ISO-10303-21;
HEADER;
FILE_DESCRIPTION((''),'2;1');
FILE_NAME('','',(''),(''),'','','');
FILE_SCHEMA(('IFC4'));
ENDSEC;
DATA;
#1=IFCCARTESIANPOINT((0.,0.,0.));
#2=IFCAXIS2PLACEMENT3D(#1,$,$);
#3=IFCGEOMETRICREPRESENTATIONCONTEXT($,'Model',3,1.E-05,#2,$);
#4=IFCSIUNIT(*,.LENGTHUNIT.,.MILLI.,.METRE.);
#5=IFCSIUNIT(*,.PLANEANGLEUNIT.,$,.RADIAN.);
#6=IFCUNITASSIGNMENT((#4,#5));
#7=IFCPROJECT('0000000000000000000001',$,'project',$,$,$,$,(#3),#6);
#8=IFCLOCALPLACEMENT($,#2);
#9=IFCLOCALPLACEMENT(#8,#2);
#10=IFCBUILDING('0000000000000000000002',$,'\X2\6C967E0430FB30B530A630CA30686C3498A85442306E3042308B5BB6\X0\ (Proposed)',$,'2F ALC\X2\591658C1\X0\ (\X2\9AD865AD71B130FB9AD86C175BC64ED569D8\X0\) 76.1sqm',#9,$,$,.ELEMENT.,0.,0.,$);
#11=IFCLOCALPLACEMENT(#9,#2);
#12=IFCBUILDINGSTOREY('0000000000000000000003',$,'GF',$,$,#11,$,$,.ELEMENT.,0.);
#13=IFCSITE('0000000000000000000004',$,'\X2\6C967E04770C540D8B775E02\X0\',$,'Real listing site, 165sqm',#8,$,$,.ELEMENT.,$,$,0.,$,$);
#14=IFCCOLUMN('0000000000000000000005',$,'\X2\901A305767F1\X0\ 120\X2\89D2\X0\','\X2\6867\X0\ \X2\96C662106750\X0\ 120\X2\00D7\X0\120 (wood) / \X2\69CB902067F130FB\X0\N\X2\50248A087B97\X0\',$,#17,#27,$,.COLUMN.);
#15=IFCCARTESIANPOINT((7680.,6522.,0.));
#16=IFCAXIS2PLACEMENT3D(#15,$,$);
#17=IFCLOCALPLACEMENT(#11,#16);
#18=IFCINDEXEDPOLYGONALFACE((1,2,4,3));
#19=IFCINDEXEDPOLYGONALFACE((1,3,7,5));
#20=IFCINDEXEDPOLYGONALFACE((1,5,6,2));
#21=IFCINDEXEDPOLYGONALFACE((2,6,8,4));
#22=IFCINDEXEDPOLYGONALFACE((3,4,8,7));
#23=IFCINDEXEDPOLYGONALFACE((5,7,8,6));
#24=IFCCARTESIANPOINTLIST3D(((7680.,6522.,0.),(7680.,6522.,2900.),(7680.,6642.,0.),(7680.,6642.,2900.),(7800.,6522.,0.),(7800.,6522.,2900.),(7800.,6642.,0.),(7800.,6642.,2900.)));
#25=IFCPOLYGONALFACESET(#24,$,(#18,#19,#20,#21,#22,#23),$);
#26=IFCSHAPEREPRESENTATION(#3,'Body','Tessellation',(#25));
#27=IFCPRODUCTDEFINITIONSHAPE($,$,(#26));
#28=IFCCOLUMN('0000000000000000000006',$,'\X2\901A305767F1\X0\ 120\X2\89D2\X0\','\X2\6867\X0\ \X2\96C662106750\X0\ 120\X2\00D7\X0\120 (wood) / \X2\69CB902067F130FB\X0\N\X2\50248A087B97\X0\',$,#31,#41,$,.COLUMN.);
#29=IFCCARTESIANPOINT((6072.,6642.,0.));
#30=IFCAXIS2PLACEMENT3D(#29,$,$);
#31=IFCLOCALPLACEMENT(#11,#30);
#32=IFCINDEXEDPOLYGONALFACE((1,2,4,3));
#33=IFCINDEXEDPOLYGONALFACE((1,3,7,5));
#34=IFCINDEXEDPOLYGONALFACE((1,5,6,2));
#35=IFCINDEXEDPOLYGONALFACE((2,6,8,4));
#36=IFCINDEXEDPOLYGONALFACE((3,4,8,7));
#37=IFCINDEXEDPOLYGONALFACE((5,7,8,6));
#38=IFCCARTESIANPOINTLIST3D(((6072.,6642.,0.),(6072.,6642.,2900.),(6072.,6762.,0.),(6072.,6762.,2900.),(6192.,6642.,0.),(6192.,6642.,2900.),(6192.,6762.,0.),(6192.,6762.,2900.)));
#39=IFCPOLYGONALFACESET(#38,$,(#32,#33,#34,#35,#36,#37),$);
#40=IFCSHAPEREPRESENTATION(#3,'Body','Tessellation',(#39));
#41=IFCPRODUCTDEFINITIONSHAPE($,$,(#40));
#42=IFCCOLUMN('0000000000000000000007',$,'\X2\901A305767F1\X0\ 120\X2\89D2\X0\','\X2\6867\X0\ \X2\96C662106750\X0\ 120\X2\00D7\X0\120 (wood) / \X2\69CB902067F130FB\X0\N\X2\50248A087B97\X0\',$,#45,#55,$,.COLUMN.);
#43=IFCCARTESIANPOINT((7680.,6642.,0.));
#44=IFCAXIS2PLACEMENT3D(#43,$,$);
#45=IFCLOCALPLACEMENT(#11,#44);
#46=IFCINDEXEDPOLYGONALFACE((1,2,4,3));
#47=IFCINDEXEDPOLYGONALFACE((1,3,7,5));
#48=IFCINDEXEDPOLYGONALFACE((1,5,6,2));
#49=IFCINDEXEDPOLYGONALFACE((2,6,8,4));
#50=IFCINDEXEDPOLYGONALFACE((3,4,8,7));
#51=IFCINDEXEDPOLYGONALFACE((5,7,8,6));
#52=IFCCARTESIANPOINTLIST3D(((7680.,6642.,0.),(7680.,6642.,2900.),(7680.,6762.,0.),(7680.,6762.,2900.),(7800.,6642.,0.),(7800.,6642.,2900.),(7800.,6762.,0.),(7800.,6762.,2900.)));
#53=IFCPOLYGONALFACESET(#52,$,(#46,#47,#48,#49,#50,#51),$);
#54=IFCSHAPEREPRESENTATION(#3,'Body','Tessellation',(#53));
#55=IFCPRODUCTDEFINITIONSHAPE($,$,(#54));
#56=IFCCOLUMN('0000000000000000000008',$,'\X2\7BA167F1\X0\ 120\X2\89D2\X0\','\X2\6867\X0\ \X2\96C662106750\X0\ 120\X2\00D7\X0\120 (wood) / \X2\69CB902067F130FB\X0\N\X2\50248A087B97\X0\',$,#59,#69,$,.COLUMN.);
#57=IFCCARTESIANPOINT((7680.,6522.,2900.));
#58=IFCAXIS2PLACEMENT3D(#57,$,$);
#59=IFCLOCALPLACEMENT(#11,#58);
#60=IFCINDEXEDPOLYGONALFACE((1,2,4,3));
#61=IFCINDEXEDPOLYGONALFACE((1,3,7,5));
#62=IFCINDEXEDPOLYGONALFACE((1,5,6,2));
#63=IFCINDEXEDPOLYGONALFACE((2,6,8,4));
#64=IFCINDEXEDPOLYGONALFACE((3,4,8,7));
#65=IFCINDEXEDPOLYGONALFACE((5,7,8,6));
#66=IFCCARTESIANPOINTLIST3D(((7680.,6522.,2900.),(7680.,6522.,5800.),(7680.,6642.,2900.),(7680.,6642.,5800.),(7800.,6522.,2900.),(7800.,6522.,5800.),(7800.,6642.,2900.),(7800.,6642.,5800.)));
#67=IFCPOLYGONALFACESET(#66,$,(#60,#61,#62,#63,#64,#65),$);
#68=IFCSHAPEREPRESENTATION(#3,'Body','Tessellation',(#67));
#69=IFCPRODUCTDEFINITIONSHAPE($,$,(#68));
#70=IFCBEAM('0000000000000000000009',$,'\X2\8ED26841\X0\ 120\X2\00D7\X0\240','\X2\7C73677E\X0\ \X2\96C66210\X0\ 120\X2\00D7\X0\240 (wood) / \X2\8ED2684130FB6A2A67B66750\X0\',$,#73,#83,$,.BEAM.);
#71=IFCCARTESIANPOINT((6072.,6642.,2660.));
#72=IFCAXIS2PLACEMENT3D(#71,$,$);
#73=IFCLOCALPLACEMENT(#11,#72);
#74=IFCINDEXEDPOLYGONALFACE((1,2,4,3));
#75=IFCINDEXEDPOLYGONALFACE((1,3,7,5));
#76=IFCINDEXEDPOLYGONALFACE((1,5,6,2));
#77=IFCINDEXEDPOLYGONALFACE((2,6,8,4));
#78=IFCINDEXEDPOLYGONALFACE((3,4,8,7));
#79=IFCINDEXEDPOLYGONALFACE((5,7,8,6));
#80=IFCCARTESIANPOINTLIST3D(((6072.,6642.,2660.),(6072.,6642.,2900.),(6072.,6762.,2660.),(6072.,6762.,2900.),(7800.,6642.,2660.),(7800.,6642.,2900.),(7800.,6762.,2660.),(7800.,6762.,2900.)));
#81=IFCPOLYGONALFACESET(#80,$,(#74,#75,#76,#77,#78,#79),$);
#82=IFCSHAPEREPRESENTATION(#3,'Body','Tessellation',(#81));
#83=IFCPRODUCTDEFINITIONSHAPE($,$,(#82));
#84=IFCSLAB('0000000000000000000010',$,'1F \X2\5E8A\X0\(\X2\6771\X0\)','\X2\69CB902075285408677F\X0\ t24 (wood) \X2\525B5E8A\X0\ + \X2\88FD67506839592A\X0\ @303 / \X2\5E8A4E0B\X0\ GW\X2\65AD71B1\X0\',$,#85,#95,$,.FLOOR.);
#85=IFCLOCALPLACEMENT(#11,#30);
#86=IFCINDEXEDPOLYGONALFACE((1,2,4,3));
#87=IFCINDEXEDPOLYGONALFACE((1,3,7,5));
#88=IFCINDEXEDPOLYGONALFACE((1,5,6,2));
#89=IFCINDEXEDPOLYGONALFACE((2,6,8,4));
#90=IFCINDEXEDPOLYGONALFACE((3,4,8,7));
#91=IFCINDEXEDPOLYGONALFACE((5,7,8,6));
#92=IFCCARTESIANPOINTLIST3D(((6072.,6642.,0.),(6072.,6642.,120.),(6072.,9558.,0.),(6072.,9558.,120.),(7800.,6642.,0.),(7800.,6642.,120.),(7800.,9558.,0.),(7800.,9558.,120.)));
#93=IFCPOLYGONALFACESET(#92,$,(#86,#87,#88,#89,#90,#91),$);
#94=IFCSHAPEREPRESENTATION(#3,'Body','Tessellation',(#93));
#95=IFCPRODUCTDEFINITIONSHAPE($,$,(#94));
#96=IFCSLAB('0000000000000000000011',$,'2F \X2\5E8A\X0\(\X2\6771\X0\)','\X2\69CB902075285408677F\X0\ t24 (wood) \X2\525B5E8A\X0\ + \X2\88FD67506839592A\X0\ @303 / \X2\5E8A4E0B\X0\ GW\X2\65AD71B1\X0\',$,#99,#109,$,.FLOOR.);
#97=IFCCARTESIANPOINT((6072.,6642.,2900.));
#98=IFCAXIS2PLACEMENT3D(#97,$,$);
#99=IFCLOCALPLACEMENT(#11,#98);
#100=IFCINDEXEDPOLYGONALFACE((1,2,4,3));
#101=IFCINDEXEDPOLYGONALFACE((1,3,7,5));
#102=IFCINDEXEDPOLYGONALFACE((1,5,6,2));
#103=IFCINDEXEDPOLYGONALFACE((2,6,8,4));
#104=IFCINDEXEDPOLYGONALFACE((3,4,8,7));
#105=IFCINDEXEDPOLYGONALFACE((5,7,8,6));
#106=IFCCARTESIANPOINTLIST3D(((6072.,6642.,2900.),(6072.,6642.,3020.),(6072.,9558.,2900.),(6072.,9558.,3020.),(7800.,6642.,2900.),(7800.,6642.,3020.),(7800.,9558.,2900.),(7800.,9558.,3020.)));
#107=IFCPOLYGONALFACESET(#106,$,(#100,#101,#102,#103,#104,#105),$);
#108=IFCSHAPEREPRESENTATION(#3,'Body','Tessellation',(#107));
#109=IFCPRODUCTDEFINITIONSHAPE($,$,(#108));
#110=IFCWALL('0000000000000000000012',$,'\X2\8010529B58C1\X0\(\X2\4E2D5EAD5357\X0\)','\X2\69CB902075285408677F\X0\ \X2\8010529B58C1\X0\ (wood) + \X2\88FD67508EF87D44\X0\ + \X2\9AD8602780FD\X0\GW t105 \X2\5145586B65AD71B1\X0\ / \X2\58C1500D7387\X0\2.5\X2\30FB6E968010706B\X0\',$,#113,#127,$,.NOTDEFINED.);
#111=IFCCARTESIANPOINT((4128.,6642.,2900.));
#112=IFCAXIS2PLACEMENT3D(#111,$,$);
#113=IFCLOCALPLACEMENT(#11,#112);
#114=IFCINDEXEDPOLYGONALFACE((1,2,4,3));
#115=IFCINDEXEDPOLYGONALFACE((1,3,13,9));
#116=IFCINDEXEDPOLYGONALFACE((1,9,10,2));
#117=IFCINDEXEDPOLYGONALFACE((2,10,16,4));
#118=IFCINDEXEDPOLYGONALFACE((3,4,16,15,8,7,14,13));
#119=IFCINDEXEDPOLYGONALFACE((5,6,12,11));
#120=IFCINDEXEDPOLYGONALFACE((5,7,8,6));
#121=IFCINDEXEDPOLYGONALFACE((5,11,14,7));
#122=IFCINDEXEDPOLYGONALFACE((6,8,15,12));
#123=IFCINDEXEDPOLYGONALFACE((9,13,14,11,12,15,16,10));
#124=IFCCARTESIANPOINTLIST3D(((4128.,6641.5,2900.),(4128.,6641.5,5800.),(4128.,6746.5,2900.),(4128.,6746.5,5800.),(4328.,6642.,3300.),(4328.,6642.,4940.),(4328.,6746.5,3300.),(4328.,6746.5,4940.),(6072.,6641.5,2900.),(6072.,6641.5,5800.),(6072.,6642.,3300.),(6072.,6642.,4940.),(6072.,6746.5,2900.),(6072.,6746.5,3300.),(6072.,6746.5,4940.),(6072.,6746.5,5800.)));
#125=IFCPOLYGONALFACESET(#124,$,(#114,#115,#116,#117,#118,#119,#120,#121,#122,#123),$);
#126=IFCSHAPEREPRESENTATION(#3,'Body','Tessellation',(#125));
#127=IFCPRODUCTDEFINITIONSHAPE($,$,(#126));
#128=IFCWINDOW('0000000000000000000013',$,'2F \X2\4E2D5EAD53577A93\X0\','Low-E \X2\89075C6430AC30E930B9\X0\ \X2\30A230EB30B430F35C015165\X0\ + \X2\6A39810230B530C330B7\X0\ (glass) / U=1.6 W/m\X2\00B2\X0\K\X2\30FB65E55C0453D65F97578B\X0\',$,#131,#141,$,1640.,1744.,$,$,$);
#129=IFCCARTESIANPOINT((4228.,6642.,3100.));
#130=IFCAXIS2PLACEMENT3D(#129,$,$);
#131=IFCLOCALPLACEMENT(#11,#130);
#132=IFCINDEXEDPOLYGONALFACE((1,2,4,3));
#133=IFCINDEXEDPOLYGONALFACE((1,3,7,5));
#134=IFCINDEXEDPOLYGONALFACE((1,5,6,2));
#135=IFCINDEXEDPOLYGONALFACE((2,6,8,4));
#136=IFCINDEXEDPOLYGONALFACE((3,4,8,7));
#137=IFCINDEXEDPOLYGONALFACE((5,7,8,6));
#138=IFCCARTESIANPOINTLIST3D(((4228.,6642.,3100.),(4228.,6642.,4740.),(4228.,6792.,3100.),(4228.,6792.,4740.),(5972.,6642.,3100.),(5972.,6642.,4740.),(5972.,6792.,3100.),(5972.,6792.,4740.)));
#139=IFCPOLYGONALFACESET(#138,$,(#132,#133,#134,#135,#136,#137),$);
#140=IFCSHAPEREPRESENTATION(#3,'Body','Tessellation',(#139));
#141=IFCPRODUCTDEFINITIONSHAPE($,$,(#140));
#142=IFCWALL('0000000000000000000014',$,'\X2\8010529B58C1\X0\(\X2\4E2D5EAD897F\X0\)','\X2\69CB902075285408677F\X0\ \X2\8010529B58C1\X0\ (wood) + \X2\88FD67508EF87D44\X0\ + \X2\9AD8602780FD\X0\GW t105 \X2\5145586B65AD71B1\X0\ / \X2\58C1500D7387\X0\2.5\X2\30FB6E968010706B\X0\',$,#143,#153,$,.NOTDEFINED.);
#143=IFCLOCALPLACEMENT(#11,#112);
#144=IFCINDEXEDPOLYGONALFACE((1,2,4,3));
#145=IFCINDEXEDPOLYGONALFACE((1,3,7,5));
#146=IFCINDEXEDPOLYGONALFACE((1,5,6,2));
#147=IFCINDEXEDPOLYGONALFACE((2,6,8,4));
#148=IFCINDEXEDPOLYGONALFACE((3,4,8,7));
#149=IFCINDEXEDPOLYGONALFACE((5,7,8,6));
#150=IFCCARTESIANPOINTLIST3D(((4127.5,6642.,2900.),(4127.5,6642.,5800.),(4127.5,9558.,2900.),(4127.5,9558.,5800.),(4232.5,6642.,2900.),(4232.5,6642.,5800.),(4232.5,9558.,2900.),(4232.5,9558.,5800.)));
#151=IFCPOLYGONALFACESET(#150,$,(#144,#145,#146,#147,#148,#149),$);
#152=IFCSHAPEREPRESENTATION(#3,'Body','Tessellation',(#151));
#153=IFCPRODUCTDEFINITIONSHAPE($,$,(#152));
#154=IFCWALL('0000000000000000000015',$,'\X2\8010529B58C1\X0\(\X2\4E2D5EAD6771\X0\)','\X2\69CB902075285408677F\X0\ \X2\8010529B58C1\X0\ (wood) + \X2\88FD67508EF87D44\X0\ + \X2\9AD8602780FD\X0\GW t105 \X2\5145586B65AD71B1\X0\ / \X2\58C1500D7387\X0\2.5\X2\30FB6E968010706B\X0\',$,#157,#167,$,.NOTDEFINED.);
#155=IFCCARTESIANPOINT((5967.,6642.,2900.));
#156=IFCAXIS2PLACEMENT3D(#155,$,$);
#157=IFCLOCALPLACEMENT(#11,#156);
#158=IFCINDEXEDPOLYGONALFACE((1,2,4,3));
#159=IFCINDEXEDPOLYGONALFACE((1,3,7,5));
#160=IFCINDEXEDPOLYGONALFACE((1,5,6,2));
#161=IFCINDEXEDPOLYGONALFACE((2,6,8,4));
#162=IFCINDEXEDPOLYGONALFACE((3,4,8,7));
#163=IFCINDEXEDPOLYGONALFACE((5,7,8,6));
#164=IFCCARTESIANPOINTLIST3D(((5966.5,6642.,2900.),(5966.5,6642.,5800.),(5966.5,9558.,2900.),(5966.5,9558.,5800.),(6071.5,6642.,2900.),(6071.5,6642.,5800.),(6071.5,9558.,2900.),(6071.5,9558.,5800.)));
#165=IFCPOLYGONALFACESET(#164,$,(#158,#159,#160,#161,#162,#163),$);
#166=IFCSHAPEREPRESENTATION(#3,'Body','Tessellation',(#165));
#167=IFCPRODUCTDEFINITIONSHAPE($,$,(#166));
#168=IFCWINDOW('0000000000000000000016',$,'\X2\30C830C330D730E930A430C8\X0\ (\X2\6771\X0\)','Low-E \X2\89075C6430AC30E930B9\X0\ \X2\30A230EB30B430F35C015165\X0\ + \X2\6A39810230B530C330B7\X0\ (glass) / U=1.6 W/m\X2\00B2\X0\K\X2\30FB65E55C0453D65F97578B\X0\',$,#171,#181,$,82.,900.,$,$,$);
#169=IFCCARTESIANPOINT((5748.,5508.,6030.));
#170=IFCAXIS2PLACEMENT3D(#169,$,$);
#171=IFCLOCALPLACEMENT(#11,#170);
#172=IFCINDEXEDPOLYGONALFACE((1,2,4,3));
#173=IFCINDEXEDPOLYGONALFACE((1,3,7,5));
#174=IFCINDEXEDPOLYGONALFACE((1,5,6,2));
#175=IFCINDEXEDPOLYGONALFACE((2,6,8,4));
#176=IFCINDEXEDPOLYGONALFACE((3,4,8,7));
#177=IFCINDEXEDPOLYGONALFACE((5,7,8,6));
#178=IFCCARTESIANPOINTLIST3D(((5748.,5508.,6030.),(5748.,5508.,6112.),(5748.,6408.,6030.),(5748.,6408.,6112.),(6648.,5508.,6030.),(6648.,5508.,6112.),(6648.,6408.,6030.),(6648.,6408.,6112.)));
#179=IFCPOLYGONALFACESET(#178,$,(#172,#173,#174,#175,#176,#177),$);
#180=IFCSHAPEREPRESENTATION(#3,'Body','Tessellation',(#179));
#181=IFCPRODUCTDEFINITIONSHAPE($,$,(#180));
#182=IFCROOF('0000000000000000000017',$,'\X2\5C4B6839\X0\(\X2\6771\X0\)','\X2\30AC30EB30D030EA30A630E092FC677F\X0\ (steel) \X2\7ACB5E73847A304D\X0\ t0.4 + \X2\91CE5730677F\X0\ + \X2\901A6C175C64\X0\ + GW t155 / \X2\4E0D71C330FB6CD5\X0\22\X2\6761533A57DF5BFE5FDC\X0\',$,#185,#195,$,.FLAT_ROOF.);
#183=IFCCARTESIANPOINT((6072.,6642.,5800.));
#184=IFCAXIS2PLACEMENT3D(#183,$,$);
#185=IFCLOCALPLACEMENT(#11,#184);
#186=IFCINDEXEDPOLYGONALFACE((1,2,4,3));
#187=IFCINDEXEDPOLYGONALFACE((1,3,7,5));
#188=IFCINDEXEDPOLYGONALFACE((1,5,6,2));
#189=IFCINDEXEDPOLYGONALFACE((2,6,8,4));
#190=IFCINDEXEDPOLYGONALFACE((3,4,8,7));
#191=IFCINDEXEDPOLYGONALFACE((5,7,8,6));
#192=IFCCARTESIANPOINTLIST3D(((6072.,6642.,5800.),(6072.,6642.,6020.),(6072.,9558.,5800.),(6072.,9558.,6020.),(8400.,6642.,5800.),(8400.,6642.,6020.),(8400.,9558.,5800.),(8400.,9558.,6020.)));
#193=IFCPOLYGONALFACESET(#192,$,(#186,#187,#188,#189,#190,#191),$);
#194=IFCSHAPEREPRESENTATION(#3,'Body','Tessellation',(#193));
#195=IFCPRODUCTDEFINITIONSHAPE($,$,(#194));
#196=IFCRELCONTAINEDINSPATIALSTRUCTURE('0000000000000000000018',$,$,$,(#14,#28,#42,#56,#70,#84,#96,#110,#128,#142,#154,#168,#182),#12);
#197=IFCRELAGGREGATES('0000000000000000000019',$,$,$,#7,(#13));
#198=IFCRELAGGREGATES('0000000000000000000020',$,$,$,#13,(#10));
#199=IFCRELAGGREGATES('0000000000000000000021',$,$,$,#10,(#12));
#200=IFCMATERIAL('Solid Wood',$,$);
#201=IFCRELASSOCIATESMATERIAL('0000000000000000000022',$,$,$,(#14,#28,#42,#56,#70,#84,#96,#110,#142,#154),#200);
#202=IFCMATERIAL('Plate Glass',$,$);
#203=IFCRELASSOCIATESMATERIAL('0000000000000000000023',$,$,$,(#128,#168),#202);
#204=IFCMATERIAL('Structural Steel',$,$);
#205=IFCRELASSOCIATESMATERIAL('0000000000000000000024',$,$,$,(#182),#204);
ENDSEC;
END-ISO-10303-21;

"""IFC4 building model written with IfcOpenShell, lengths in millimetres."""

from ifc_helpers import new_model, si_unit, frame, frame_2d, origin, place, context, project, spatial, rectangle, extrude, material, element, fill, save


model = new_model("IFC4")

# Units and contexts
model_context = context("Model", 3, precision=1e-05, world=origin())
ifc_project = project(units=[si_unit("LENGTHUNIT", "METRE", prefix="MILLI"), si_unit("PLANEANGLEUNIT", "RADIAN")], contexts=[model_context])

# Site, building, storey
site_placement = place(None, origin())
site = spatial("IfcSite", under=ifc_project, at=site_placement, Name="沖縄県名護市", ObjectType="Real listing site, 165sqm", CompositionType="ELEMENT", RefElevation=0.0)
building_placement = place(site_placement, origin())
building = spatial("IfcBuilding", under=site, at=building_placement, Name="沖縄・サウナと水風呂のある家 (Proposed)", ObjectType="2F ALC外壁 (高断熱・高気密仕様) 76.1sqm", CompositionType="ELEMENT", ElevationOfRefHeight=0.0, ElevationOfTerrain=0.0)
storey_placement = place(building_placement, origin())
storey = spatial("IfcBuildingStorey", under=building, at=storey_placement, Name="GF", CompositionType="ELEMENT", Elevation=0.0)

# Columns
ifc_material_1 = material(Name="Solid Wood")
column_1_placement = place(storey_placement, frame((7680.0, 6522.0, 0.0)))
element("IfcColumn", 1, at=column_1_placement, inside=storey, material=ifc_material_1, Name="通し柱 120角", Description="桧 集成材 120×120 (wood) / 構造柱・N値計算", PredefinedType="COLUMN", context=model_context, shape_type="SweptSolid", body=[
    extrude(rectangle(XDim=120.0, YDim=120.0, at=frame_2d((60.0, 60.0))), frame((7680.0, 6522.0, 0.0)), (0.0, 0.0, 1.0), 2900.0),
])
column_2_placement = place(storey_placement, frame((6072.0, 6642.0, 0.0)))
element("IfcColumn", 2, at=column_2_placement, inside=storey, material=ifc_material_1, Name="通し柱 120角", Description="桧 集成材 120×120 (wood) / 構造柱・N値計算", PredefinedType="COLUMN", context=model_context, shape_type="SweptSolid", body=[
    extrude(rectangle(XDim=120.0, YDim=120.0, at=frame_2d((60.0, 60.0))), frame((6072.0, 6642.0, 0.0)), (0.0, 0.0, 1.0), 2900.0),
])
column_3_placement = place(storey_placement, frame((7680.0, 6642.0, 0.0)))
element("IfcColumn", 3, at=column_3_placement, inside=storey, material=ifc_material_1, Name="通し柱 120角", Description="桧 集成材 120×120 (wood) / 構造柱・N値計算", PredefinedType="COLUMN", context=model_context, shape_type="SweptSolid", body=[
    extrude(rectangle(XDim=120.0, YDim=120.0, at=frame_2d((60.0, 60.0))), frame((7680.0, 6642.0, 0.0)), (0.0, 0.0, 1.0), 2900.0),
])
column_4_placement = place(storey_placement, frame((7680.0, 6522.0, 2900.0)))
element("IfcColumn", 4, at=column_4_placement, inside=storey, material=ifc_material_1, Name="管柱 120角", Description="桧 集成材 120×120 (wood) / 構造柱・N値計算", PredefinedType="COLUMN", context=model_context, shape_type="SweptSolid", body=[
    extrude(rectangle(XDim=120.0, YDim=120.0, at=frame_2d((60.0, 60.0))), frame((7680.0, 6522.0, 2900.0)), (0.0, 0.0, 1.0), 2900.0),
])

# Beam
beam_1_placement = place(storey_placement, frame((6072.0, 6642.0, 2660.0)))
element("IfcBeam", 5, at=beam_1_placement, inside=storey, material=ifc_material_1, Name="軒桁 120×240", Description="米松 集成 120×240 (wood) / 軒桁・横架材", PredefinedType="BEAM", context=model_context, shape_type="SweptSolid", body=[
    extrude(rectangle(XDim=1728.0, YDim=120.0, at=frame_2d((864.0, 60.0))), frame((6072.0, 6642.0, 2660.0)), (0.0, 0.0, 1.0), 240.0),
])

# Slabs
slab_1_placement = place(storey_placement, frame((6072.0, 6642.0, 0.0)))
element("IfcSlab", 6, at=slab_1_placement, inside=storey, material=ifc_material_1, Name="1F 床(東)", Description="構造用合板 t24 (wood) 剛床 + 製材根太 @303 / 床下 GW断熱", PredefinedType="FLOOR", context=model_context, shape_type="SweptSolid", body=[
    extrude(rectangle(XDim=1728.0, YDim=2916.0, at=frame_2d((864.0, 1458.0))), frame((6072.0, 6642.0, 0.0)), (0.0, 0.0, 1.0), 120.0),
])
slab_2_placement = place(storey_placement, frame((6072.0, 6642.0, 2900.0)))
element("IfcSlab", 7, at=slab_2_placement, inside=storey, material=ifc_material_1, Name="2F 床(東)", Description="構造用合板 t24 (wood) 剛床 + 製材根太 @303 / 床下 GW断熱", PredefinedType="FLOOR", context=model_context, shape_type="SweptSolid", body=[
    extrude(rectangle(XDim=1728.0, YDim=2916.0, at=frame_2d((864.0, 1458.0))), frame((6072.0, 6642.0, 2900.0)), (0.0, 0.0, 1.0), 120.0),
])

# Wall, opening, window
wall_1_placement = place(storey_placement, frame((4128.0, 6642.0, 2900.0)))
wall_1 = element("IfcWall", 8, at=wall_1_placement, inside=storey, material=ifc_material_1, Name="耐力壁(中庭南)", Description="構造用合板 耐力壁 (wood) + 製材軸組 + 高性能GW t105 充填断熱 / 壁倍率2.5・準耐火", PredefinedType="NOTDEFINED", context=model_context, shape_type="SweptSolid", body=[
    extrude(rectangle(XDim=1944.0, YDim=105.0, at=frame_2d((972.0, 52.0))), frame((4128.0, 6642.0, 2900.0)), (0.0, 0.0, 1.0), 2900.0),
])
opening_placement = place(storey_placement, frame((4228.0, 6642.0, 3100.0)))
opening = element("IfcOpeningElement", 9, at=opening_placement, cuts=wall_1, PredefinedType="NOTDEFINED", context=model_context, shape_type="SweptSolid", body=[
    extrude(rectangle(XDim=1744.0, YDim=150.0, at=frame_2d((872.0, 75.0))), frame((4228.0, 6642.0, 3100.0)), (0.0, 0.0, 1.0), 1640.0),
])
ifc_material_2 = material(Name="Plate Glass")
window_1_placement = place(storey_placement, frame((4228.0, 6642.0, 3100.0)))
window_1 = element("IfcWindow", 10, at=window_1_placement, inside=storey, material=ifc_material_2, Name="2F 中庭南窓", Description="Low-E 複層ガラス アルゴン封入 + 樹脂サッシ (glass) / U=1.6 W/m²K・日射取得型", OverallHeight=1640.0, OverallWidth=1744.0, context=model_context, shape_type="SweptSolid", body=[
    extrude(rectangle(XDim=1744.0, YDim=150.0, at=frame_2d((872.0, 75.0))), frame((4228.0, 6642.0, 3100.0)), (0.0, 0.0, 1.0), 1640.0),
])
fill(opening, window_1)

# Walls
wall_2_placement = place(storey_placement, frame((4128.0, 6642.0, 2900.0)))
element("IfcWall", 11, at=wall_2_placement, inside=storey, material=ifc_material_1, Name="耐力壁(中庭西)", Description="構造用合板 耐力壁 (wood) + 製材軸組 + 高性能GW t105 充填断熱 / 壁倍率2.5・準耐火", PredefinedType="NOTDEFINED", context=model_context, shape_type="SweptSolid", body=[
    extrude(rectangle(XDim=105.0, YDim=2916.0, at=frame_2d((52.0, 1458.0))), frame((4128.0, 6642.0, 2900.0)), (0.0, 0.0, 1.0), 2900.0),
])
wall_3_placement = place(storey_placement, frame((5967.0, 6642.0, 2900.0)))
element("IfcWall", 12, at=wall_3_placement, inside=storey, material=ifc_material_1, Name="耐力壁(中庭東)", Description="構造用合板 耐力壁 (wood) + 製材軸組 + 高性能GW t105 充填断熱 / 壁倍率2.5・準耐火", PredefinedType="NOTDEFINED", context=model_context, shape_type="SweptSolid", body=[
    extrude(rectangle(XDim=105.0, YDim=2916.0, at=frame_2d((52.0, 1458.0))), frame((5967.0, 6642.0, 2900.0)), (0.0, 0.0, 1.0), 2900.0),
])

# Window
window_2_placement = place(storey_placement, frame((5748.0, 5508.0, 6030.0)))
element("IfcWindow", 13, at=window_2_placement, inside=storey, material=ifc_material_2, Name="トップライト (東)", Description="Low-E 複層ガラス アルゴン封入 + 樹脂サッシ (glass) / U=1.6 W/m²K・日射取得型", OverallHeight=82.0, OverallWidth=900.0, context=model_context, shape_type="SweptSolid", body=[
    extrude(rectangle(XDim=900.0, YDim=900.0, at=frame_2d((450.0, 450.0))), frame((5748.0, 5508.0, 6030.0)), (0.0, 0.0, 1.0), 82.0),
])

# Roof
ifc_material_3 = material(Name="Structural Steel")
for number, where, name in (
    (14, (6072.0, 6642.0, 5800.0), "屋根(東)"),
):
    element("IfcRoof", number, at=place(storey_placement, frame(where)), inside=storey, material=ifc_material_3, Name=name, Description="ガルバリウム鋼板 (steel) 立平葺き t0.4 + 野地板 + 通気層 + GW t155 / 不燃・法22条区域対応", PredefinedType="FLAT_ROOF", context=model_context, shape_type="SweptSolid", body=[
        extrude(rectangle(XDim=2328.0, YDim=2916.0, at=frame_2d((1164.0, 1458.0))), frame((6072.0, 6642.0, 5800.0)), (0.0, 0.0, 1.0), 220.0),
    ])

save(model, "model.ifc")
